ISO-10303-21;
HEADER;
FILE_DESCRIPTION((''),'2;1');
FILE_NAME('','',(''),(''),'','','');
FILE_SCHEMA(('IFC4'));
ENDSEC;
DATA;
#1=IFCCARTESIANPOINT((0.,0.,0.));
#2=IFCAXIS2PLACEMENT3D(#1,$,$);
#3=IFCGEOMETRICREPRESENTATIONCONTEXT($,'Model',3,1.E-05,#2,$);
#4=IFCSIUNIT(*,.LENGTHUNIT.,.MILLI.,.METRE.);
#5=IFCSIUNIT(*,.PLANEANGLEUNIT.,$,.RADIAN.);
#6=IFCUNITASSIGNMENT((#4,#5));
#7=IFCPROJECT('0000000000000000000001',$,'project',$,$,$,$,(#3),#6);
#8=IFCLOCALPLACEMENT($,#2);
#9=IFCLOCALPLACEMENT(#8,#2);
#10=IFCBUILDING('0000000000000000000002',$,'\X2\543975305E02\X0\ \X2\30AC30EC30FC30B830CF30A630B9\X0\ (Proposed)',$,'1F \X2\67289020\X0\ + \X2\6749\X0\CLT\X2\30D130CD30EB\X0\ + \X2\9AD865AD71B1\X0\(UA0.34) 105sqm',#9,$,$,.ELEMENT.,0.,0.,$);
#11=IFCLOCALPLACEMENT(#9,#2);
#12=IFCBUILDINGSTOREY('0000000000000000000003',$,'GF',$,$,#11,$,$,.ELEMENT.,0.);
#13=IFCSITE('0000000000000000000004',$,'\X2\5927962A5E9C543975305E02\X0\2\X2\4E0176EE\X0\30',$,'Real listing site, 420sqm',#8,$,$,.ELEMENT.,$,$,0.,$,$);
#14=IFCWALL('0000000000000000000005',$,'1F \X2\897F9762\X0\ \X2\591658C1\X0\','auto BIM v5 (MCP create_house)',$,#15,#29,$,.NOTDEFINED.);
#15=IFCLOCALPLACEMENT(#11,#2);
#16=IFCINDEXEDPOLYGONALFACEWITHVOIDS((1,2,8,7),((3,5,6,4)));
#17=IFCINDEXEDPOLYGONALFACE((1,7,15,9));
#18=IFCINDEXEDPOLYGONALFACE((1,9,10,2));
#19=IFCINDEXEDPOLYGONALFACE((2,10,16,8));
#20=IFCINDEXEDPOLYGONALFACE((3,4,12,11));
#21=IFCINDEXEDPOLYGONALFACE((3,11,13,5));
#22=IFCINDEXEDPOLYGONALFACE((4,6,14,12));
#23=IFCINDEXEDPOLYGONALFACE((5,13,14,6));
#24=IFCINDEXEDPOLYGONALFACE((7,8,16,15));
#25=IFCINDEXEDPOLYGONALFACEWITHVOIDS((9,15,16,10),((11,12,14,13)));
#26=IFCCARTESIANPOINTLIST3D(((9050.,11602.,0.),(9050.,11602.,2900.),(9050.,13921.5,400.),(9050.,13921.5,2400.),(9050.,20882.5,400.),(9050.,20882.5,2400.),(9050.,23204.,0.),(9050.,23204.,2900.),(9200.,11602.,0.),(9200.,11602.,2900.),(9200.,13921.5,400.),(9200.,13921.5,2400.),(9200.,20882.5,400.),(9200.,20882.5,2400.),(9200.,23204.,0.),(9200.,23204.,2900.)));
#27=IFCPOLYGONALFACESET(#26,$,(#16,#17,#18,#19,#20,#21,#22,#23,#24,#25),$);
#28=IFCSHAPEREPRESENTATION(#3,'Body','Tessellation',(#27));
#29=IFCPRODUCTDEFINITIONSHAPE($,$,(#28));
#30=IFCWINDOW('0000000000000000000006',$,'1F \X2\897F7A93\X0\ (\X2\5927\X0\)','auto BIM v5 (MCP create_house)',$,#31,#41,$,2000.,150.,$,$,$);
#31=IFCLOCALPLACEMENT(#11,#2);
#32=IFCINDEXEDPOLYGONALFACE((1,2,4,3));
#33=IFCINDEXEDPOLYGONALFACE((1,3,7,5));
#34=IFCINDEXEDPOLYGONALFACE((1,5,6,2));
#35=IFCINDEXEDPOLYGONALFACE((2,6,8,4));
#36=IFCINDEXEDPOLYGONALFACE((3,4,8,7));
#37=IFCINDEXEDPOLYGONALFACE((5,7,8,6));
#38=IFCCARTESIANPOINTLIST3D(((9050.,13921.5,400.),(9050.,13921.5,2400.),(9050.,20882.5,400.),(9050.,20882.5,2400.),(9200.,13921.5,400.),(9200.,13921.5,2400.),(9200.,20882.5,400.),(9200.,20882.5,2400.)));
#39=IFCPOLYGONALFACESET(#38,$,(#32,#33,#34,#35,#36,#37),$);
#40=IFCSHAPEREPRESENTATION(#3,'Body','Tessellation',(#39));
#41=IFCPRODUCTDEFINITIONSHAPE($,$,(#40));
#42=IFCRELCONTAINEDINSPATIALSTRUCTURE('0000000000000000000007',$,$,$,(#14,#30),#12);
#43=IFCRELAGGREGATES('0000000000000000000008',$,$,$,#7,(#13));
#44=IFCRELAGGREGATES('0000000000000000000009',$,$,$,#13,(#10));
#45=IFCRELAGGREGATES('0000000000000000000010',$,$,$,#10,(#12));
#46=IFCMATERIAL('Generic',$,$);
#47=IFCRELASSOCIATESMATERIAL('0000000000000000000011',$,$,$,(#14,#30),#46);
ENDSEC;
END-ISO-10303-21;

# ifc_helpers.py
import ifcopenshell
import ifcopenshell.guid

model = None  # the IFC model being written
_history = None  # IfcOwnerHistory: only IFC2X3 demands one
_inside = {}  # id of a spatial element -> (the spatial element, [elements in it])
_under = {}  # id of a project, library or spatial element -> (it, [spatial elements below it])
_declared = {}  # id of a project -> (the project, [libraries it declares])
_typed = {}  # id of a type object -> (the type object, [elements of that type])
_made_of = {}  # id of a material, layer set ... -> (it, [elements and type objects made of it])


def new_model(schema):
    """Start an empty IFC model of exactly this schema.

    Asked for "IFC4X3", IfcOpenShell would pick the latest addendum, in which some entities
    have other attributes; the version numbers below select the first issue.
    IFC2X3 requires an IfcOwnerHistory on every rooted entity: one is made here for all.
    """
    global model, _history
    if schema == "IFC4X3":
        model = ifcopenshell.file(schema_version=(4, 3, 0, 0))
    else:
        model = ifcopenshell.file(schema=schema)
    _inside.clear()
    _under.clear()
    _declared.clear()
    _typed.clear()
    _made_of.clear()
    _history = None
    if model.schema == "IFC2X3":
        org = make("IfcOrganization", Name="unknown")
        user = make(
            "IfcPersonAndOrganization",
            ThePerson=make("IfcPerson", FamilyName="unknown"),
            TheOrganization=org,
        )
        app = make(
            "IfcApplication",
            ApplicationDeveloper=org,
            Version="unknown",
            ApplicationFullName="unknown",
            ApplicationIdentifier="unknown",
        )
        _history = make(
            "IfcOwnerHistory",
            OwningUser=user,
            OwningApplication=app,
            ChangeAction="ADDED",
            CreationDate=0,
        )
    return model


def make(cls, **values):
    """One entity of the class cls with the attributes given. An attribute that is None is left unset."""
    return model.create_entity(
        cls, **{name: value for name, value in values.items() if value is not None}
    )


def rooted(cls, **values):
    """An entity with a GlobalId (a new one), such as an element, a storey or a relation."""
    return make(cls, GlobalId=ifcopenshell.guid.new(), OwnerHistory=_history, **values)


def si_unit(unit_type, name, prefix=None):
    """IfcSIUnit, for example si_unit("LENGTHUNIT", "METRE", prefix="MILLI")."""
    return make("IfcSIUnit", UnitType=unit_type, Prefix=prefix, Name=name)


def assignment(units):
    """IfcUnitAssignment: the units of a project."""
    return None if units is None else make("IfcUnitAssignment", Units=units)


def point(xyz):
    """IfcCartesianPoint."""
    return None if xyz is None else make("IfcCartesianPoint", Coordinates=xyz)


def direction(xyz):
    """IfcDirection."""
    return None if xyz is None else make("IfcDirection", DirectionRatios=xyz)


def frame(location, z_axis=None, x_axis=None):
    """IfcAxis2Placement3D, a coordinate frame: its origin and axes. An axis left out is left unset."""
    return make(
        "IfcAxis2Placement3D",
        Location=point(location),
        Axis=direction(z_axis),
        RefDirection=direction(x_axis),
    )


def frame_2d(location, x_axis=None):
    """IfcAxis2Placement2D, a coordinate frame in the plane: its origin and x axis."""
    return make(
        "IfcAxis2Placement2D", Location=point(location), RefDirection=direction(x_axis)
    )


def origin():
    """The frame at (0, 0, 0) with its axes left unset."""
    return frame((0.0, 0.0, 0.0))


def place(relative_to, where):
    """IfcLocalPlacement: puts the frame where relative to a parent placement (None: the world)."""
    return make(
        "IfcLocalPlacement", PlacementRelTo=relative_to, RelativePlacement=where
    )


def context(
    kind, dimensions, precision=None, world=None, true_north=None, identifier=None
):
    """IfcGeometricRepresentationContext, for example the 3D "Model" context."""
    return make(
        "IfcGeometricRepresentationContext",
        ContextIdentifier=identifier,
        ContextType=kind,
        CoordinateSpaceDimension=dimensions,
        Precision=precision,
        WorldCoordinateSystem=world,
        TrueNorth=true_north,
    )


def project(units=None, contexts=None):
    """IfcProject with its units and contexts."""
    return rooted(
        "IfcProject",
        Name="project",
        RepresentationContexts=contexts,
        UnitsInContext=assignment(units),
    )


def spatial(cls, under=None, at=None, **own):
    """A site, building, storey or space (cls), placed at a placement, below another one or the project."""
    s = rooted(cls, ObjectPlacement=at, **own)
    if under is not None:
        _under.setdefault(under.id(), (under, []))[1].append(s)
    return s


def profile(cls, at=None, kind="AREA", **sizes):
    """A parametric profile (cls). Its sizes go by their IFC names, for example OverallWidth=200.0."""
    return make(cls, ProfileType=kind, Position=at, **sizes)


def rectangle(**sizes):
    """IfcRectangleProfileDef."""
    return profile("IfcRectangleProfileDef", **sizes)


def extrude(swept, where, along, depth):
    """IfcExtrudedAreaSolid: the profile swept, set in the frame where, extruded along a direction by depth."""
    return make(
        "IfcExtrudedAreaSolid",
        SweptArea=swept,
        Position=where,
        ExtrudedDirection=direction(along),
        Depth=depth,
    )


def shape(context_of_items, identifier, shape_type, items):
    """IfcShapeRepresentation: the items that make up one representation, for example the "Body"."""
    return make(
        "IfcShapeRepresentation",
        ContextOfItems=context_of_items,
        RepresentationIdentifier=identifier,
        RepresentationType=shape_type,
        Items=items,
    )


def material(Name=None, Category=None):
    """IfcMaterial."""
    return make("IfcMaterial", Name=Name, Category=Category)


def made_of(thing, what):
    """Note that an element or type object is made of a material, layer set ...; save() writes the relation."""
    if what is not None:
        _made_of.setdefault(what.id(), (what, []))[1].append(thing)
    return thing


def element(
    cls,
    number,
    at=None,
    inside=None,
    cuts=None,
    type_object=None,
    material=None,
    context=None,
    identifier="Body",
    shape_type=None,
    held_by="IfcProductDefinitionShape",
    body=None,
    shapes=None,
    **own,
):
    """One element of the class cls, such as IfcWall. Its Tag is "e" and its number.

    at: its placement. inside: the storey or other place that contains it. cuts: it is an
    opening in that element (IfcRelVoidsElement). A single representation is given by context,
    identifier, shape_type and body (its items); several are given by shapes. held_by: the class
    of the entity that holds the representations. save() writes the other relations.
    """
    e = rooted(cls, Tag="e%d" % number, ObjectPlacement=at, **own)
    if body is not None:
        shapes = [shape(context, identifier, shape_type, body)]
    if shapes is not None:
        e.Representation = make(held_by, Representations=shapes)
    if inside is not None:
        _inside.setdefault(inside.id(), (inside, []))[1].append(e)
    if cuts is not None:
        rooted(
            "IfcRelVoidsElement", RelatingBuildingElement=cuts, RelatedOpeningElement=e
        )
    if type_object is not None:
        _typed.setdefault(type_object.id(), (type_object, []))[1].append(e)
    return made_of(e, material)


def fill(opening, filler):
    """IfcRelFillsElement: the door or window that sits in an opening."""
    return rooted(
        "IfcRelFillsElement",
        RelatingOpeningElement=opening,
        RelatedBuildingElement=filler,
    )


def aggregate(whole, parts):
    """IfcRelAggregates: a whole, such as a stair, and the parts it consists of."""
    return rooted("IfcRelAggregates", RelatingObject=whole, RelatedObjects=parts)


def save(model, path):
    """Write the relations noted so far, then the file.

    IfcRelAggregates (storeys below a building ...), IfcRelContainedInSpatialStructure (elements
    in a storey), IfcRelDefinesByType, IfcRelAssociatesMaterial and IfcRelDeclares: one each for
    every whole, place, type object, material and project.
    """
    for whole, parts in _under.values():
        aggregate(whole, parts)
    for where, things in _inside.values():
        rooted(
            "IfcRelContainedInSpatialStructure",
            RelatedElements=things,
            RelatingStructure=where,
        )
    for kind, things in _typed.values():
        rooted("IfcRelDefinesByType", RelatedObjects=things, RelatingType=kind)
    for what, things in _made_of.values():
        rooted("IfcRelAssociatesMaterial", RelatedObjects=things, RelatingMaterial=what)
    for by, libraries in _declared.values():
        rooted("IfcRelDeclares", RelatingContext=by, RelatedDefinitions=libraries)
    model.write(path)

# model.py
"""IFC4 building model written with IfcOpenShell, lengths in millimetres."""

from ifc_helpers import new_model, si_unit, frame, frame_2d, origin, place, context, project, spatial, rectangle, extrude, material, element, fill, save


model = new_model("IFC4")

# Units and contexts
model_context = context("Model", 3, precision=1e-05, world=origin())
ifc_project = project(units=[si_unit("LENGTHUNIT", "METRE", prefix="MILLI"), si_unit("PLANEANGLEUNIT", "RADIAN")], contexts=[model_context])

# Site, building, storey
site_placement = place(None, origin())
site = spatial("IfcSite", under=ifc_project, at=site_placement, Name="大阪府吹田市2丁目30", ObjectType="Real listing site, 420sqm", CompositionType="ELEMENT", RefElevation=0.0)
building_placement = place(site_placement, origin())
building = spatial("IfcBuilding", under=site, at=building_placement, Name="吹田市 ガレージハウス (Proposed)", ObjectType="1F 木造 + 杉CLTパネル + 高断熱(UA0.34) 105sqm", CompositionType="ELEMENT", ElevationOfRefHeight=0.0, ElevationOfTerrain=0.0)
storey_placement = place(building_placement, origin())
storey = spatial("IfcBuildingStorey", under=building, at=storey_placement, Name="GF", CompositionType="ELEMENT", Elevation=0.0)

# Shared definitions
ifc_material = material(Name="Generic")

# Wall, opening, window
wall_1_placement = place(storey_placement, frame((4525.0, 5801.0, 0.0)))
wall_1 = element("IfcWall", 1, at=wall_1_placement, inside=storey, material=ifc_material, Name="1F 西面 外壁", Description="auto BIM v5 (MCP create_house)", PredefinedType="NOTDEFINED", context=model_context, shape_type="SweptSolid", body=[
    extrude(rectangle(XDim=150.0, YDim=11602.0, at=frame_2d((75.0, 5801.0))), frame((4525.0, 5801.0, 0.0)), (0.0, 0.0, 1.0), 2900.0),
])
opening_1_placement = place(storey_placement, frame((4525.0, 6961.0, 200.0)))
opening_1 = element("IfcOpeningElement", 2, at=opening_1_placement, cuts=wall_1, PredefinedType="NOTDEFINED", context=model_context, shape_type="SweptSolid", body=[
    extrude(rectangle(XDim=150.0, YDim=6961.0, at=frame_2d((75.0, 3480.0))), frame((4525.0, 6961.0, 200.0)), (0.0, 0.0, 1.0), 2000.0),
])
window_1_placement = place(storey_placement, frame((4525.0, 6961.0, 200.0)))
window_1 = element("IfcWindow", 3, at=window_1_placement, inside=storey, material=ifc_material, Name="1F 西窓 (大)", Description="auto BIM v5 (MCP create_house)", OverallHeight=2000.0, OverallWidth=150.0, context=model_context, shape_type="SweptSolid", body=[
    extrude(rectangle(XDim=150.0, YDim=6961.0, at=frame_2d((75.0, 3480.0))), frame((4525.0, 6961.0, 200.0)), (0.0, 0.0, 1.0), 2000.0),
])
fill(opening_1, window_1)

save(model, "model.ifc")
